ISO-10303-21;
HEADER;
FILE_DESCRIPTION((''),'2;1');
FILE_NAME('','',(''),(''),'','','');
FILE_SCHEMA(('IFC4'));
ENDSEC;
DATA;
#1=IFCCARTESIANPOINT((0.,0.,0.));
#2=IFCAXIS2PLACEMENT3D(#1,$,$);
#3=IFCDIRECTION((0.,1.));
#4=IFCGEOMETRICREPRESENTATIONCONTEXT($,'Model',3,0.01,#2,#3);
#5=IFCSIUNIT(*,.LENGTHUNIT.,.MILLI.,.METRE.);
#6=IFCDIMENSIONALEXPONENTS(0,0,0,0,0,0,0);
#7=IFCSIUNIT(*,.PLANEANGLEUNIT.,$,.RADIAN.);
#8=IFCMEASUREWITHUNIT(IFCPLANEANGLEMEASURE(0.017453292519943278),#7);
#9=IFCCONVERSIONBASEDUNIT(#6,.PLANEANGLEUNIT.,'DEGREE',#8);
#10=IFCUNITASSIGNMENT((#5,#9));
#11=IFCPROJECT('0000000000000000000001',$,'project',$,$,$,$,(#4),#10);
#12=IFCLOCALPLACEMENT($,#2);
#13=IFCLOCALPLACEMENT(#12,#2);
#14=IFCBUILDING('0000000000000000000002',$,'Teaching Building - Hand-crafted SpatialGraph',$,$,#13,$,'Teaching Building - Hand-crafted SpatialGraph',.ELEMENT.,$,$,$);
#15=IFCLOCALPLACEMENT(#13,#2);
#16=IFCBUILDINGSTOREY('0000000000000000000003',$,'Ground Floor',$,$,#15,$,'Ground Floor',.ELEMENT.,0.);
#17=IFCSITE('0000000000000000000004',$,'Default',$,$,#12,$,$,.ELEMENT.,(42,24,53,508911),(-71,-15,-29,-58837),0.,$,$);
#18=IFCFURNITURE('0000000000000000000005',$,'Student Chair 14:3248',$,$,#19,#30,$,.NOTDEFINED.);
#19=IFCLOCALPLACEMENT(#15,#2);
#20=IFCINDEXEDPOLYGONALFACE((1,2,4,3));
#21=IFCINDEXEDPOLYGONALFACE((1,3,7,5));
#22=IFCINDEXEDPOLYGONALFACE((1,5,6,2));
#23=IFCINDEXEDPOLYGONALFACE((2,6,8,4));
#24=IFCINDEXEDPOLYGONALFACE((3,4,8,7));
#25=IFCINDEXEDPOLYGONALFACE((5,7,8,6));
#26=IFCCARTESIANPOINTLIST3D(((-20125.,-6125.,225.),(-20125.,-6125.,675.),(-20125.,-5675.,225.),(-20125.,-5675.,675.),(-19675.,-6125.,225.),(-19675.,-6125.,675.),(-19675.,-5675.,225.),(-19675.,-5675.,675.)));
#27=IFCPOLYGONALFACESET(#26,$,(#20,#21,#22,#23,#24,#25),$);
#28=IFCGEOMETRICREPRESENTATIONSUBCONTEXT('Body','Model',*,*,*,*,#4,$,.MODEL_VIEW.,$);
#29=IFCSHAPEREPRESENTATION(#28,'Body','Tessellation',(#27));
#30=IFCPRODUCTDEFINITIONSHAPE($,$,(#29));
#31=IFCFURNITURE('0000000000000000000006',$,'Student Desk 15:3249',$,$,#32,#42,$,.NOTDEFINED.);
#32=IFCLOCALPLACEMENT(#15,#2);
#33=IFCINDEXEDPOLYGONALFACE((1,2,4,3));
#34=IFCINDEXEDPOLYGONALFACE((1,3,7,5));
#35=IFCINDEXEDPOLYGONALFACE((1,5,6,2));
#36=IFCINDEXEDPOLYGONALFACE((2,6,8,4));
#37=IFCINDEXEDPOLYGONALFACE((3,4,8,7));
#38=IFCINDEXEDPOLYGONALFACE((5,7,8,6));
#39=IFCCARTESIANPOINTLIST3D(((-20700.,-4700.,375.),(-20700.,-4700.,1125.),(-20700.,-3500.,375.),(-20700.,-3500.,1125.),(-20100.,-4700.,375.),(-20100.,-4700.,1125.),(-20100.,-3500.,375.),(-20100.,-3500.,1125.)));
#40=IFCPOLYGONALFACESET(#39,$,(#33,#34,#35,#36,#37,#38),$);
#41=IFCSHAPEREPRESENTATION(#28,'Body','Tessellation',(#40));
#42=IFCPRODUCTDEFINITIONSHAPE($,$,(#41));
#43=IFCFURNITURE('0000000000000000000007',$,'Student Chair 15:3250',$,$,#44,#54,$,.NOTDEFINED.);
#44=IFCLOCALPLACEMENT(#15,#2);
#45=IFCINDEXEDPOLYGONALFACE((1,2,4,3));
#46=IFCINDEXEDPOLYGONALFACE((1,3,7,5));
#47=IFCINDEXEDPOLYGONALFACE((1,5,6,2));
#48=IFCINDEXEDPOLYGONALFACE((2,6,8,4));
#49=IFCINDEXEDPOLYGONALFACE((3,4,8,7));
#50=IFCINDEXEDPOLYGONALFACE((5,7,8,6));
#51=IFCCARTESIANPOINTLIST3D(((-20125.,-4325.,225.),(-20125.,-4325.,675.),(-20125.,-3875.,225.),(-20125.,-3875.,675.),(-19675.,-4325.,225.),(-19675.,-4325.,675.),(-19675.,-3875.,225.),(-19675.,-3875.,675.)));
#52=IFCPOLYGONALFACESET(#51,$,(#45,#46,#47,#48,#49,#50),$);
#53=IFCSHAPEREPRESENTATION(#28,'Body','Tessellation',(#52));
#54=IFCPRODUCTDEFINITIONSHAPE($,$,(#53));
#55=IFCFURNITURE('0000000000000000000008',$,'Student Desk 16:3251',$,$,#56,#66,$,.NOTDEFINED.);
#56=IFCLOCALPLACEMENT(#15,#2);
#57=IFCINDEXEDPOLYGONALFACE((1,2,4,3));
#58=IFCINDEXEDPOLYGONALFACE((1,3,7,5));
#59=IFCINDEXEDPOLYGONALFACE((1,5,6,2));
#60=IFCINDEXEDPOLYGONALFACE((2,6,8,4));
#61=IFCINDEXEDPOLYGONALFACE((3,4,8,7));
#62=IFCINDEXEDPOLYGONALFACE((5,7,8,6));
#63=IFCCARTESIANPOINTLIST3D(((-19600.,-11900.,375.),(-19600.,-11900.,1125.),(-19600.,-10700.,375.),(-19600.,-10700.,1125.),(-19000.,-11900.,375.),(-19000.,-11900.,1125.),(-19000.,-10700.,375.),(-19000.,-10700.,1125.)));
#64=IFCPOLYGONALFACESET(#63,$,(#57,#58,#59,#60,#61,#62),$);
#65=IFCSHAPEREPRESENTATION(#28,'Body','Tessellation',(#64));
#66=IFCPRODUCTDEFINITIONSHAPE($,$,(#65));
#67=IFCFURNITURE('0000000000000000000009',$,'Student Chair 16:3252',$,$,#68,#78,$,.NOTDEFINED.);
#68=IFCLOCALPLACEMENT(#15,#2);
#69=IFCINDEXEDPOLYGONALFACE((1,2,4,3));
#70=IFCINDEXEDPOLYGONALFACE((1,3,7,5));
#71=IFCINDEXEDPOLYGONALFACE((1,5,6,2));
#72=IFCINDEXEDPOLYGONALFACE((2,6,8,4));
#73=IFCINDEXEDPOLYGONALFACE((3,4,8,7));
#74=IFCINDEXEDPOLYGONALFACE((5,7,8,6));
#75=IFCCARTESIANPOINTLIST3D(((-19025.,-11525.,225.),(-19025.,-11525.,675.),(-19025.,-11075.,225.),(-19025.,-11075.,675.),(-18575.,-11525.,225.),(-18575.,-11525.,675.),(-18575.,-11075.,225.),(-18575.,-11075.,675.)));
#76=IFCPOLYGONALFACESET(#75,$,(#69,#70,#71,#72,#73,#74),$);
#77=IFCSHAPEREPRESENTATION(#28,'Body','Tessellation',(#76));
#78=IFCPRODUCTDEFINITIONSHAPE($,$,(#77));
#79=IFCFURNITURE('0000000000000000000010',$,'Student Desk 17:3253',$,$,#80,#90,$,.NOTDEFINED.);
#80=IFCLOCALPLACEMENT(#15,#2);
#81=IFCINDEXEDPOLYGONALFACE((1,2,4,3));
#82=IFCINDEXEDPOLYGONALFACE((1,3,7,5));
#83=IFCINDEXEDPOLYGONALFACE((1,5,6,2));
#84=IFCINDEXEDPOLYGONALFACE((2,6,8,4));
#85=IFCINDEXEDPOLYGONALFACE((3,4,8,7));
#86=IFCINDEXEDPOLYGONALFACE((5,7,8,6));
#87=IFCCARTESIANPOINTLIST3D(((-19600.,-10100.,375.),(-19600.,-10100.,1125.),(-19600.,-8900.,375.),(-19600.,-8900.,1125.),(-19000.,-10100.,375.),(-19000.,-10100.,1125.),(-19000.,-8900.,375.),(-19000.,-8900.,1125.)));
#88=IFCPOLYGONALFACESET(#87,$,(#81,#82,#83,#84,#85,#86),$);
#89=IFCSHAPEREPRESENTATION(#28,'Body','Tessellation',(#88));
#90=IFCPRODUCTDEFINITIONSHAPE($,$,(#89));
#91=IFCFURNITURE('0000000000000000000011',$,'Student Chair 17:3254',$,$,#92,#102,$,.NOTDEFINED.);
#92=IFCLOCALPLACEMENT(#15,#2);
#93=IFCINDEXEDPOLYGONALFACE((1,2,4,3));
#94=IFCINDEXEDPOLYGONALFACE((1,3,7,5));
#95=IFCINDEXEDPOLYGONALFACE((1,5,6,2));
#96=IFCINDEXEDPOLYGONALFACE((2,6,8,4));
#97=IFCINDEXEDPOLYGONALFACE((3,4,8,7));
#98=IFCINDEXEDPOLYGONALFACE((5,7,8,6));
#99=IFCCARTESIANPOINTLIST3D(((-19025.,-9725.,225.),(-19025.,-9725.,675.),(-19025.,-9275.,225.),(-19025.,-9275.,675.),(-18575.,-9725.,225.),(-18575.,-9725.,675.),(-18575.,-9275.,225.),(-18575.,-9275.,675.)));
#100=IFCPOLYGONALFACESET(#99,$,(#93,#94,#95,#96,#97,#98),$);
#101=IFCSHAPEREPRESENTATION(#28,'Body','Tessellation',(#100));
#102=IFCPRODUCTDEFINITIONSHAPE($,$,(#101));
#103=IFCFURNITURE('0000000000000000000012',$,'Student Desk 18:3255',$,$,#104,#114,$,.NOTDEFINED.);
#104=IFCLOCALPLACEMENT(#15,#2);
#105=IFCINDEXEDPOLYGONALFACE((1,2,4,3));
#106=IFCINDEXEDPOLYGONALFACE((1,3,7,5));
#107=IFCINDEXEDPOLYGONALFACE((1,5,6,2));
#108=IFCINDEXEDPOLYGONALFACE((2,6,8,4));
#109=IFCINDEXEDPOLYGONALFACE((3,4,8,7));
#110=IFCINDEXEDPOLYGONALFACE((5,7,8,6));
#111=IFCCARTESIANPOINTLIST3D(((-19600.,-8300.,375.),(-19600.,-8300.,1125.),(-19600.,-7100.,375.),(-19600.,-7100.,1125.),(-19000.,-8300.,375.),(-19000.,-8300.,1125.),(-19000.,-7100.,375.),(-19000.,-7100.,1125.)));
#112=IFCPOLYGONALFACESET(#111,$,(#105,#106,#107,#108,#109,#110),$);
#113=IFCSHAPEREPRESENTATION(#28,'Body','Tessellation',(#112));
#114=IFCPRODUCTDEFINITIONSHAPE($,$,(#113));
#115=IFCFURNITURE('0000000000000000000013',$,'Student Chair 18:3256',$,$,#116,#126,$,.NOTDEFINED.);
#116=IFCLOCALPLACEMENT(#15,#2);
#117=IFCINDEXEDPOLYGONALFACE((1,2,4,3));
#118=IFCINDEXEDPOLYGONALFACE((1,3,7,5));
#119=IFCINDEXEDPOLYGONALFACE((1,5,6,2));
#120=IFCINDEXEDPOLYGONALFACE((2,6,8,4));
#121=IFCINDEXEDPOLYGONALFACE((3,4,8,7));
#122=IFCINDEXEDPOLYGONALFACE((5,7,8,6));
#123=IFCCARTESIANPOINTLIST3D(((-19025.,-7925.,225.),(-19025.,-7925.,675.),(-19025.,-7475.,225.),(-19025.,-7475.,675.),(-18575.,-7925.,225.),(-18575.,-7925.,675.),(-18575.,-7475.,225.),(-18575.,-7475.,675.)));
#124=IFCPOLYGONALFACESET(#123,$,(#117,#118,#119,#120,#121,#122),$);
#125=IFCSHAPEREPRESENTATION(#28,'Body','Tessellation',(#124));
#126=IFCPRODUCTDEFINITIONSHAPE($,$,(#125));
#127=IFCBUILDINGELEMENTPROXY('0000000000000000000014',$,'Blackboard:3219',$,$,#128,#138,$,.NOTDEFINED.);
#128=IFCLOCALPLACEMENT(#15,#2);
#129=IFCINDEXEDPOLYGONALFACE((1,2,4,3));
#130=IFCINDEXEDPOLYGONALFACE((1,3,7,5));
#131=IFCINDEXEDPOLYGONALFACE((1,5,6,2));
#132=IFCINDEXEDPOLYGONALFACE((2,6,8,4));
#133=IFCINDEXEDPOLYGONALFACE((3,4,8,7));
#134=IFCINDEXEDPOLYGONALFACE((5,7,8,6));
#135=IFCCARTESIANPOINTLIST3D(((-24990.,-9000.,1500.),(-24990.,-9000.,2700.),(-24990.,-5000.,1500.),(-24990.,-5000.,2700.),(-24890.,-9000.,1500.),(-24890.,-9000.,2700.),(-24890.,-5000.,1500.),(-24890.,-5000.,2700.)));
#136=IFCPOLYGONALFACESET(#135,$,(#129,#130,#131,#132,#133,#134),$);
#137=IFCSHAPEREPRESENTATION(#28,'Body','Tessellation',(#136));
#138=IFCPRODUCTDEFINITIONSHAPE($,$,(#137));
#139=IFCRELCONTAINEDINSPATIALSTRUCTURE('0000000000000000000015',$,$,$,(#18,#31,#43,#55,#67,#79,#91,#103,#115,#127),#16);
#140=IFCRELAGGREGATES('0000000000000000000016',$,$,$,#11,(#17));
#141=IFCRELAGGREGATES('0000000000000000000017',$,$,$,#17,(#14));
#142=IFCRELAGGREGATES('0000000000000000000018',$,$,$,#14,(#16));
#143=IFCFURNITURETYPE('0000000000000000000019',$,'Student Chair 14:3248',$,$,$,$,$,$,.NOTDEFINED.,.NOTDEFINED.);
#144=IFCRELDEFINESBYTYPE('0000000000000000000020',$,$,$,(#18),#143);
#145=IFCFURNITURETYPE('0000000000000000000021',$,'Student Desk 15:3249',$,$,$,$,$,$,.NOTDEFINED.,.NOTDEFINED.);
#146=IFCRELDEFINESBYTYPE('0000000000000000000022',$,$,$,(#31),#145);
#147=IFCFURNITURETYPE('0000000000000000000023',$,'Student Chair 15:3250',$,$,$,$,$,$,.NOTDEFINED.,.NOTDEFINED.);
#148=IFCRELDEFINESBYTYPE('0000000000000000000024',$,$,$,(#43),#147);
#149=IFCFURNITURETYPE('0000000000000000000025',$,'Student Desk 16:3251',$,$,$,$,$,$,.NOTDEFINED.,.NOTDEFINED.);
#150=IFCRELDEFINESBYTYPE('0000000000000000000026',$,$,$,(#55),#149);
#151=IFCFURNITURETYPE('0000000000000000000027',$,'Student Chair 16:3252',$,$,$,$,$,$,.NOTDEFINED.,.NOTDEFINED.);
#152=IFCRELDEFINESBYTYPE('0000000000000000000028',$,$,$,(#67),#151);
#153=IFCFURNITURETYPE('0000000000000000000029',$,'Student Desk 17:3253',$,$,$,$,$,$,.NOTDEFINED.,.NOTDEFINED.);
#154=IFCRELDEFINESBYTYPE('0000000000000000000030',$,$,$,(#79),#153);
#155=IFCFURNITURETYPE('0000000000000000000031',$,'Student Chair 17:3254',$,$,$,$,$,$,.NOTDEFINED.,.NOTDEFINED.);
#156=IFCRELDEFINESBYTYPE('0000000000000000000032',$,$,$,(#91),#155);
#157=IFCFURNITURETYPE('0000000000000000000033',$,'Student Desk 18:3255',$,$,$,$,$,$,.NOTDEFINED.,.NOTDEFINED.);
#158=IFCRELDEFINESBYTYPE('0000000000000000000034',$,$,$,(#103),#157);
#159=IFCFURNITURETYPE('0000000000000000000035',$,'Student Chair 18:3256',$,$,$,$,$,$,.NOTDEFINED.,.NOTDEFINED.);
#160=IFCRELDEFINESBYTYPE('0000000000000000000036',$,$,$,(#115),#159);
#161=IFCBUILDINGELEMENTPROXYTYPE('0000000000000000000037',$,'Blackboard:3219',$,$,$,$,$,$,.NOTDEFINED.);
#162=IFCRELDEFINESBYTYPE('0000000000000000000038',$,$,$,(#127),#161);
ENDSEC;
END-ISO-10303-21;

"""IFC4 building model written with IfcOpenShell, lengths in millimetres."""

from ifc_helpers import new_model, entity, si_unit, converted_unit, direction, frame, frame_2d, origin, origin_2d_with_axis, place, context, subcontext, project, spatial, rectangle, extrude, type_object, element, save


model = new_model("IFC4")

# Units and contexts
model_context = context("Model", 3, precision=0.01, world=origin(), true_north=direction((0.0, 1.0)))
body_context = subcontext(model_context, "Body", "Model", "MODEL_VIEW")
ifc_project = project(units=[si_unit("LENGTHUNIT", "METRE", prefix="MILLI"), converted_unit("PLANEANGLEUNIT", "DEGREE", entity("IfcPlaneAngleMeasure", 0.017453292519943278), si_unit("PLANEANGLEUNIT", "RADIAN"), dimensions=[0, 0, 0, 0, 0, 0, 0])], contexts=[model_context])

# Site, building, storey
site_placement = place(None, origin())
site = spatial("IfcSite", under=ifc_project, at=site_placement, Name="Default", CompositionType="ELEMENT", RefLatitude=(42, 24, 53, 508911), RefLongitude=(-71, -15, -29, -58837), RefElevation=0.0)
building_placement = place(site_placement, origin())
building = spatial("IfcBuilding", under=site, at=building_placement, Name="Teaching Building - Hand-crafted SpatialGraph", LongName="Teaching Building - Hand-crafted SpatialGraph", CompositionType="ELEMENT")
storey_placement = place(building_placement, origin())
storey = spatial("IfcBuildingStorey", under=building, at=storey_placement, Name="Ground Floor", LongName="Ground Floor", CompositionType="ELEMENT", Elevation=0.0)

# Furniture
furniture_type_1 = type_object("IfcFurnitureType", Name="Student Chair 14:3248", PredefinedType="NOTDEFINED")
furniture_1_placement = place(storey_placement, origin())
element("IfcFurniture", 1, at=furniture_1_placement, inside=storey, type_object=furniture_type_1, Name="Student Chair 14:3248", PredefinedType="NOTDEFINED", context=body_context, shape_type="SweptSolid", body=[
    extrude(rectangle(XDim=450.0, YDim=450.0, at=origin_2d_with_axis()), frame((-19900.0, -5900.0, 225.0)), (0.0, 0.0, 1.0), 450.0),
])
furniture_type_2 = type_object("IfcFurnitureType", Name="Student Desk 15:3249", PredefinedType="NOTDEFINED")
furniture_2_placement = place(storey_placement, origin())
element("IfcFurniture", 2, at=furniture_2_placement, inside=storey, type_object=furniture_type_2, Name="Student Desk 15:3249", PredefinedType="NOTDEFINED", context=body_context, shape_type="SweptSolid", body=[
    extrude(rectangle(XDim=1200.0, YDim=600.0, at=origin_2d_with_axis()), frame((-20400.0, -4100.0, 375.0), z_axis=(0.0, 0.0, 1.0), x_axis=(0.0, 1.0, 0.0)), (0.0, 0.0, 1.0), 750.0),
])
furniture_type_3 = type_object("IfcFurnitureType", Name="Student Chair 15:3250", PredefinedType="NOTDEFINED")
furniture_3_placement = place(storey_placement, origin())
element("IfcFurniture", 3, at=furniture_3_placement, inside=storey, type_object=furniture_type_3, Name="Student Chair 15:3250", PredefinedType="NOTDEFINED", context=body_context, shape_type="SweptSolid", body=[
    extrude(rectangle(XDim=450.0, YDim=450.0, at=origin_2d_with_axis()), frame((-19900.0, -4100.0, 225.0)), (0.0, 0.0, 1.0), 450.0),
])
furniture_type_4 = type_object("IfcFurnitureType", Name="Student Desk 16:3251", PredefinedType="NOTDEFINED")
furniture_4_placement = place(storey_placement, origin())
element("IfcFurniture", 4, at=furniture_4_placement, inside=storey, type_object=furniture_type_4, Name="Student Desk 16:3251", PredefinedType="NOTDEFINED", context=body_context, shape_type="SweptSolid", body=[
    extrude(rectangle(XDim=1200.0, YDim=600.0, at=frame_2d((0.0, 0.0), x_axis=(1.0, 0.0))), frame((-19300.0, -11300.0, 375.0), z_axis=(0.0, 0.0, 1.0), x_axis=(0.0, 1.0, 0.0)), (0.0, 0.0, 1.0), 750.0),
])
furniture_type_5 = type_object("IfcFurnitureType", Name="Student Chair 16:3252", PredefinedType="NOTDEFINED")
furniture_5_placement = place(storey_placement, origin())
element("IfcFurniture", 5, at=furniture_5_placement, inside=storey, type_object=furniture_type_5, Name="Student Chair 16:3252", PredefinedType="NOTDEFINED", context=body_context, shape_type="SweptSolid", body=[
    extrude(rectangle(XDim=450.0, YDim=450.0, at=origin_2d_with_axis()), frame((-18800.0, -11300.0, 225.0)), (0.0, 0.0, 1.0), 450.0),
])
furniture_type_6 = type_object("IfcFurnitureType", Name="Student Desk 17:3253", PredefinedType="NOTDEFINED")
furniture_6_placement = place(storey_placement, origin())
element("IfcFurniture", 6, at=furniture_6_placement, inside=storey, type_object=furniture_type_6, Name="Student Desk 17:3253", PredefinedType="NOTDEFINED", context=body_context, shape_type="SweptSolid", body=[
    extrude(rectangle(XDim=1200.0, YDim=600.0, at=frame_2d((0.0, 0.0), x_axis=(1.0, 0.0))), frame((-19300.0, -9500.0, 375.0), z_axis=(0.0, 0.0, 1.0), x_axis=(0.0, 1.0, 0.0)), (0.0, 0.0, 1.0), 750.0),
])
furniture_type_7 = type_object("IfcFurnitureType", Name="Student Chair 17:3254", PredefinedType="NOTDEFINED")
furniture_7_placement = place(storey_placement, origin())
element("IfcFurniture", 7, at=furniture_7_placement, inside=storey, type_object=furniture_type_7, Name="Student Chair 17:3254", PredefinedType="NOTDEFINED", context=body_context, shape_type="SweptSolid", body=[
    extrude(rectangle(XDim=450.0, YDim=450.0, at=origin_2d_with_axis()), frame((-18800.0, -9500.0, 225.0)), (0.0, 0.0, 1.0), 450.0),
])
furniture_type_8 = type_object("IfcFurnitureType", Name="Student Desk 18:3255", PredefinedType="NOTDEFINED")
furniture_8_placement = place(storey_placement, origin())
element("IfcFurniture", 8, at=furniture_8_placement, inside=storey, type_object=furniture_type_8, Name="Student Desk 18:3255", PredefinedType="NOTDEFINED", context=body_context, shape_type="SweptSolid", body=[
    extrude(rectangle(XDim=1200.0, YDim=600.0, at=frame_2d((0.0, 0.0), x_axis=(1.0, 0.0))), frame((-19300.0, -7700.0, 375.0), z_axis=(0.0, 0.0, 1.0), x_axis=(0.0, 1.0, 0.0)), (0.0, 0.0, 1.0), 750.0),
])
furniture_type_9 = type_object("IfcFurnitureType", Name="Student Chair 18:3256", PredefinedType="NOTDEFINED")
furniture_9_placement = place(storey_placement, origin())
element("IfcFurniture", 9, at=furniture_9_placement, inside=storey, type_object=furniture_type_9, Name="Student Chair 18:3256", PredefinedType="NOTDEFINED", context=body_context, shape_type="SweptSolid", body=[
    extrude(rectangle(XDim=450.0, YDim=450.0, at=frame_2d((0.0, 0.0), x_axis=(1.0, 0.0))), frame((-18800.0, -7700.0, 225.0)), (0.0, 0.0, 1.0), 450.0),
])

# Building element proxy
building_element_proxy_type = type_object("IfcBuildingElementProxyType", Name="Blackboard:3219", PredefinedType="NOTDEFINED")
proxy_placement = place(storey_placement, origin())
element("IfcBuildingElementProxy", 10, at=proxy_placement, inside=storey, type_object=building_element_proxy_type, Name="Blackboard:3219", PredefinedType="NOTDEFINED", context=body_context, shape_type="SweptSolid", body=[
    extrude(rectangle(XDim=100.0, YDim=4000.0, at=origin_2d_with_axis()), frame((-24940.0, -7000.0, 1500.0)), (0.0, 0.0, 1.0), 1200.0),
])

save(model, "model.ifc")
